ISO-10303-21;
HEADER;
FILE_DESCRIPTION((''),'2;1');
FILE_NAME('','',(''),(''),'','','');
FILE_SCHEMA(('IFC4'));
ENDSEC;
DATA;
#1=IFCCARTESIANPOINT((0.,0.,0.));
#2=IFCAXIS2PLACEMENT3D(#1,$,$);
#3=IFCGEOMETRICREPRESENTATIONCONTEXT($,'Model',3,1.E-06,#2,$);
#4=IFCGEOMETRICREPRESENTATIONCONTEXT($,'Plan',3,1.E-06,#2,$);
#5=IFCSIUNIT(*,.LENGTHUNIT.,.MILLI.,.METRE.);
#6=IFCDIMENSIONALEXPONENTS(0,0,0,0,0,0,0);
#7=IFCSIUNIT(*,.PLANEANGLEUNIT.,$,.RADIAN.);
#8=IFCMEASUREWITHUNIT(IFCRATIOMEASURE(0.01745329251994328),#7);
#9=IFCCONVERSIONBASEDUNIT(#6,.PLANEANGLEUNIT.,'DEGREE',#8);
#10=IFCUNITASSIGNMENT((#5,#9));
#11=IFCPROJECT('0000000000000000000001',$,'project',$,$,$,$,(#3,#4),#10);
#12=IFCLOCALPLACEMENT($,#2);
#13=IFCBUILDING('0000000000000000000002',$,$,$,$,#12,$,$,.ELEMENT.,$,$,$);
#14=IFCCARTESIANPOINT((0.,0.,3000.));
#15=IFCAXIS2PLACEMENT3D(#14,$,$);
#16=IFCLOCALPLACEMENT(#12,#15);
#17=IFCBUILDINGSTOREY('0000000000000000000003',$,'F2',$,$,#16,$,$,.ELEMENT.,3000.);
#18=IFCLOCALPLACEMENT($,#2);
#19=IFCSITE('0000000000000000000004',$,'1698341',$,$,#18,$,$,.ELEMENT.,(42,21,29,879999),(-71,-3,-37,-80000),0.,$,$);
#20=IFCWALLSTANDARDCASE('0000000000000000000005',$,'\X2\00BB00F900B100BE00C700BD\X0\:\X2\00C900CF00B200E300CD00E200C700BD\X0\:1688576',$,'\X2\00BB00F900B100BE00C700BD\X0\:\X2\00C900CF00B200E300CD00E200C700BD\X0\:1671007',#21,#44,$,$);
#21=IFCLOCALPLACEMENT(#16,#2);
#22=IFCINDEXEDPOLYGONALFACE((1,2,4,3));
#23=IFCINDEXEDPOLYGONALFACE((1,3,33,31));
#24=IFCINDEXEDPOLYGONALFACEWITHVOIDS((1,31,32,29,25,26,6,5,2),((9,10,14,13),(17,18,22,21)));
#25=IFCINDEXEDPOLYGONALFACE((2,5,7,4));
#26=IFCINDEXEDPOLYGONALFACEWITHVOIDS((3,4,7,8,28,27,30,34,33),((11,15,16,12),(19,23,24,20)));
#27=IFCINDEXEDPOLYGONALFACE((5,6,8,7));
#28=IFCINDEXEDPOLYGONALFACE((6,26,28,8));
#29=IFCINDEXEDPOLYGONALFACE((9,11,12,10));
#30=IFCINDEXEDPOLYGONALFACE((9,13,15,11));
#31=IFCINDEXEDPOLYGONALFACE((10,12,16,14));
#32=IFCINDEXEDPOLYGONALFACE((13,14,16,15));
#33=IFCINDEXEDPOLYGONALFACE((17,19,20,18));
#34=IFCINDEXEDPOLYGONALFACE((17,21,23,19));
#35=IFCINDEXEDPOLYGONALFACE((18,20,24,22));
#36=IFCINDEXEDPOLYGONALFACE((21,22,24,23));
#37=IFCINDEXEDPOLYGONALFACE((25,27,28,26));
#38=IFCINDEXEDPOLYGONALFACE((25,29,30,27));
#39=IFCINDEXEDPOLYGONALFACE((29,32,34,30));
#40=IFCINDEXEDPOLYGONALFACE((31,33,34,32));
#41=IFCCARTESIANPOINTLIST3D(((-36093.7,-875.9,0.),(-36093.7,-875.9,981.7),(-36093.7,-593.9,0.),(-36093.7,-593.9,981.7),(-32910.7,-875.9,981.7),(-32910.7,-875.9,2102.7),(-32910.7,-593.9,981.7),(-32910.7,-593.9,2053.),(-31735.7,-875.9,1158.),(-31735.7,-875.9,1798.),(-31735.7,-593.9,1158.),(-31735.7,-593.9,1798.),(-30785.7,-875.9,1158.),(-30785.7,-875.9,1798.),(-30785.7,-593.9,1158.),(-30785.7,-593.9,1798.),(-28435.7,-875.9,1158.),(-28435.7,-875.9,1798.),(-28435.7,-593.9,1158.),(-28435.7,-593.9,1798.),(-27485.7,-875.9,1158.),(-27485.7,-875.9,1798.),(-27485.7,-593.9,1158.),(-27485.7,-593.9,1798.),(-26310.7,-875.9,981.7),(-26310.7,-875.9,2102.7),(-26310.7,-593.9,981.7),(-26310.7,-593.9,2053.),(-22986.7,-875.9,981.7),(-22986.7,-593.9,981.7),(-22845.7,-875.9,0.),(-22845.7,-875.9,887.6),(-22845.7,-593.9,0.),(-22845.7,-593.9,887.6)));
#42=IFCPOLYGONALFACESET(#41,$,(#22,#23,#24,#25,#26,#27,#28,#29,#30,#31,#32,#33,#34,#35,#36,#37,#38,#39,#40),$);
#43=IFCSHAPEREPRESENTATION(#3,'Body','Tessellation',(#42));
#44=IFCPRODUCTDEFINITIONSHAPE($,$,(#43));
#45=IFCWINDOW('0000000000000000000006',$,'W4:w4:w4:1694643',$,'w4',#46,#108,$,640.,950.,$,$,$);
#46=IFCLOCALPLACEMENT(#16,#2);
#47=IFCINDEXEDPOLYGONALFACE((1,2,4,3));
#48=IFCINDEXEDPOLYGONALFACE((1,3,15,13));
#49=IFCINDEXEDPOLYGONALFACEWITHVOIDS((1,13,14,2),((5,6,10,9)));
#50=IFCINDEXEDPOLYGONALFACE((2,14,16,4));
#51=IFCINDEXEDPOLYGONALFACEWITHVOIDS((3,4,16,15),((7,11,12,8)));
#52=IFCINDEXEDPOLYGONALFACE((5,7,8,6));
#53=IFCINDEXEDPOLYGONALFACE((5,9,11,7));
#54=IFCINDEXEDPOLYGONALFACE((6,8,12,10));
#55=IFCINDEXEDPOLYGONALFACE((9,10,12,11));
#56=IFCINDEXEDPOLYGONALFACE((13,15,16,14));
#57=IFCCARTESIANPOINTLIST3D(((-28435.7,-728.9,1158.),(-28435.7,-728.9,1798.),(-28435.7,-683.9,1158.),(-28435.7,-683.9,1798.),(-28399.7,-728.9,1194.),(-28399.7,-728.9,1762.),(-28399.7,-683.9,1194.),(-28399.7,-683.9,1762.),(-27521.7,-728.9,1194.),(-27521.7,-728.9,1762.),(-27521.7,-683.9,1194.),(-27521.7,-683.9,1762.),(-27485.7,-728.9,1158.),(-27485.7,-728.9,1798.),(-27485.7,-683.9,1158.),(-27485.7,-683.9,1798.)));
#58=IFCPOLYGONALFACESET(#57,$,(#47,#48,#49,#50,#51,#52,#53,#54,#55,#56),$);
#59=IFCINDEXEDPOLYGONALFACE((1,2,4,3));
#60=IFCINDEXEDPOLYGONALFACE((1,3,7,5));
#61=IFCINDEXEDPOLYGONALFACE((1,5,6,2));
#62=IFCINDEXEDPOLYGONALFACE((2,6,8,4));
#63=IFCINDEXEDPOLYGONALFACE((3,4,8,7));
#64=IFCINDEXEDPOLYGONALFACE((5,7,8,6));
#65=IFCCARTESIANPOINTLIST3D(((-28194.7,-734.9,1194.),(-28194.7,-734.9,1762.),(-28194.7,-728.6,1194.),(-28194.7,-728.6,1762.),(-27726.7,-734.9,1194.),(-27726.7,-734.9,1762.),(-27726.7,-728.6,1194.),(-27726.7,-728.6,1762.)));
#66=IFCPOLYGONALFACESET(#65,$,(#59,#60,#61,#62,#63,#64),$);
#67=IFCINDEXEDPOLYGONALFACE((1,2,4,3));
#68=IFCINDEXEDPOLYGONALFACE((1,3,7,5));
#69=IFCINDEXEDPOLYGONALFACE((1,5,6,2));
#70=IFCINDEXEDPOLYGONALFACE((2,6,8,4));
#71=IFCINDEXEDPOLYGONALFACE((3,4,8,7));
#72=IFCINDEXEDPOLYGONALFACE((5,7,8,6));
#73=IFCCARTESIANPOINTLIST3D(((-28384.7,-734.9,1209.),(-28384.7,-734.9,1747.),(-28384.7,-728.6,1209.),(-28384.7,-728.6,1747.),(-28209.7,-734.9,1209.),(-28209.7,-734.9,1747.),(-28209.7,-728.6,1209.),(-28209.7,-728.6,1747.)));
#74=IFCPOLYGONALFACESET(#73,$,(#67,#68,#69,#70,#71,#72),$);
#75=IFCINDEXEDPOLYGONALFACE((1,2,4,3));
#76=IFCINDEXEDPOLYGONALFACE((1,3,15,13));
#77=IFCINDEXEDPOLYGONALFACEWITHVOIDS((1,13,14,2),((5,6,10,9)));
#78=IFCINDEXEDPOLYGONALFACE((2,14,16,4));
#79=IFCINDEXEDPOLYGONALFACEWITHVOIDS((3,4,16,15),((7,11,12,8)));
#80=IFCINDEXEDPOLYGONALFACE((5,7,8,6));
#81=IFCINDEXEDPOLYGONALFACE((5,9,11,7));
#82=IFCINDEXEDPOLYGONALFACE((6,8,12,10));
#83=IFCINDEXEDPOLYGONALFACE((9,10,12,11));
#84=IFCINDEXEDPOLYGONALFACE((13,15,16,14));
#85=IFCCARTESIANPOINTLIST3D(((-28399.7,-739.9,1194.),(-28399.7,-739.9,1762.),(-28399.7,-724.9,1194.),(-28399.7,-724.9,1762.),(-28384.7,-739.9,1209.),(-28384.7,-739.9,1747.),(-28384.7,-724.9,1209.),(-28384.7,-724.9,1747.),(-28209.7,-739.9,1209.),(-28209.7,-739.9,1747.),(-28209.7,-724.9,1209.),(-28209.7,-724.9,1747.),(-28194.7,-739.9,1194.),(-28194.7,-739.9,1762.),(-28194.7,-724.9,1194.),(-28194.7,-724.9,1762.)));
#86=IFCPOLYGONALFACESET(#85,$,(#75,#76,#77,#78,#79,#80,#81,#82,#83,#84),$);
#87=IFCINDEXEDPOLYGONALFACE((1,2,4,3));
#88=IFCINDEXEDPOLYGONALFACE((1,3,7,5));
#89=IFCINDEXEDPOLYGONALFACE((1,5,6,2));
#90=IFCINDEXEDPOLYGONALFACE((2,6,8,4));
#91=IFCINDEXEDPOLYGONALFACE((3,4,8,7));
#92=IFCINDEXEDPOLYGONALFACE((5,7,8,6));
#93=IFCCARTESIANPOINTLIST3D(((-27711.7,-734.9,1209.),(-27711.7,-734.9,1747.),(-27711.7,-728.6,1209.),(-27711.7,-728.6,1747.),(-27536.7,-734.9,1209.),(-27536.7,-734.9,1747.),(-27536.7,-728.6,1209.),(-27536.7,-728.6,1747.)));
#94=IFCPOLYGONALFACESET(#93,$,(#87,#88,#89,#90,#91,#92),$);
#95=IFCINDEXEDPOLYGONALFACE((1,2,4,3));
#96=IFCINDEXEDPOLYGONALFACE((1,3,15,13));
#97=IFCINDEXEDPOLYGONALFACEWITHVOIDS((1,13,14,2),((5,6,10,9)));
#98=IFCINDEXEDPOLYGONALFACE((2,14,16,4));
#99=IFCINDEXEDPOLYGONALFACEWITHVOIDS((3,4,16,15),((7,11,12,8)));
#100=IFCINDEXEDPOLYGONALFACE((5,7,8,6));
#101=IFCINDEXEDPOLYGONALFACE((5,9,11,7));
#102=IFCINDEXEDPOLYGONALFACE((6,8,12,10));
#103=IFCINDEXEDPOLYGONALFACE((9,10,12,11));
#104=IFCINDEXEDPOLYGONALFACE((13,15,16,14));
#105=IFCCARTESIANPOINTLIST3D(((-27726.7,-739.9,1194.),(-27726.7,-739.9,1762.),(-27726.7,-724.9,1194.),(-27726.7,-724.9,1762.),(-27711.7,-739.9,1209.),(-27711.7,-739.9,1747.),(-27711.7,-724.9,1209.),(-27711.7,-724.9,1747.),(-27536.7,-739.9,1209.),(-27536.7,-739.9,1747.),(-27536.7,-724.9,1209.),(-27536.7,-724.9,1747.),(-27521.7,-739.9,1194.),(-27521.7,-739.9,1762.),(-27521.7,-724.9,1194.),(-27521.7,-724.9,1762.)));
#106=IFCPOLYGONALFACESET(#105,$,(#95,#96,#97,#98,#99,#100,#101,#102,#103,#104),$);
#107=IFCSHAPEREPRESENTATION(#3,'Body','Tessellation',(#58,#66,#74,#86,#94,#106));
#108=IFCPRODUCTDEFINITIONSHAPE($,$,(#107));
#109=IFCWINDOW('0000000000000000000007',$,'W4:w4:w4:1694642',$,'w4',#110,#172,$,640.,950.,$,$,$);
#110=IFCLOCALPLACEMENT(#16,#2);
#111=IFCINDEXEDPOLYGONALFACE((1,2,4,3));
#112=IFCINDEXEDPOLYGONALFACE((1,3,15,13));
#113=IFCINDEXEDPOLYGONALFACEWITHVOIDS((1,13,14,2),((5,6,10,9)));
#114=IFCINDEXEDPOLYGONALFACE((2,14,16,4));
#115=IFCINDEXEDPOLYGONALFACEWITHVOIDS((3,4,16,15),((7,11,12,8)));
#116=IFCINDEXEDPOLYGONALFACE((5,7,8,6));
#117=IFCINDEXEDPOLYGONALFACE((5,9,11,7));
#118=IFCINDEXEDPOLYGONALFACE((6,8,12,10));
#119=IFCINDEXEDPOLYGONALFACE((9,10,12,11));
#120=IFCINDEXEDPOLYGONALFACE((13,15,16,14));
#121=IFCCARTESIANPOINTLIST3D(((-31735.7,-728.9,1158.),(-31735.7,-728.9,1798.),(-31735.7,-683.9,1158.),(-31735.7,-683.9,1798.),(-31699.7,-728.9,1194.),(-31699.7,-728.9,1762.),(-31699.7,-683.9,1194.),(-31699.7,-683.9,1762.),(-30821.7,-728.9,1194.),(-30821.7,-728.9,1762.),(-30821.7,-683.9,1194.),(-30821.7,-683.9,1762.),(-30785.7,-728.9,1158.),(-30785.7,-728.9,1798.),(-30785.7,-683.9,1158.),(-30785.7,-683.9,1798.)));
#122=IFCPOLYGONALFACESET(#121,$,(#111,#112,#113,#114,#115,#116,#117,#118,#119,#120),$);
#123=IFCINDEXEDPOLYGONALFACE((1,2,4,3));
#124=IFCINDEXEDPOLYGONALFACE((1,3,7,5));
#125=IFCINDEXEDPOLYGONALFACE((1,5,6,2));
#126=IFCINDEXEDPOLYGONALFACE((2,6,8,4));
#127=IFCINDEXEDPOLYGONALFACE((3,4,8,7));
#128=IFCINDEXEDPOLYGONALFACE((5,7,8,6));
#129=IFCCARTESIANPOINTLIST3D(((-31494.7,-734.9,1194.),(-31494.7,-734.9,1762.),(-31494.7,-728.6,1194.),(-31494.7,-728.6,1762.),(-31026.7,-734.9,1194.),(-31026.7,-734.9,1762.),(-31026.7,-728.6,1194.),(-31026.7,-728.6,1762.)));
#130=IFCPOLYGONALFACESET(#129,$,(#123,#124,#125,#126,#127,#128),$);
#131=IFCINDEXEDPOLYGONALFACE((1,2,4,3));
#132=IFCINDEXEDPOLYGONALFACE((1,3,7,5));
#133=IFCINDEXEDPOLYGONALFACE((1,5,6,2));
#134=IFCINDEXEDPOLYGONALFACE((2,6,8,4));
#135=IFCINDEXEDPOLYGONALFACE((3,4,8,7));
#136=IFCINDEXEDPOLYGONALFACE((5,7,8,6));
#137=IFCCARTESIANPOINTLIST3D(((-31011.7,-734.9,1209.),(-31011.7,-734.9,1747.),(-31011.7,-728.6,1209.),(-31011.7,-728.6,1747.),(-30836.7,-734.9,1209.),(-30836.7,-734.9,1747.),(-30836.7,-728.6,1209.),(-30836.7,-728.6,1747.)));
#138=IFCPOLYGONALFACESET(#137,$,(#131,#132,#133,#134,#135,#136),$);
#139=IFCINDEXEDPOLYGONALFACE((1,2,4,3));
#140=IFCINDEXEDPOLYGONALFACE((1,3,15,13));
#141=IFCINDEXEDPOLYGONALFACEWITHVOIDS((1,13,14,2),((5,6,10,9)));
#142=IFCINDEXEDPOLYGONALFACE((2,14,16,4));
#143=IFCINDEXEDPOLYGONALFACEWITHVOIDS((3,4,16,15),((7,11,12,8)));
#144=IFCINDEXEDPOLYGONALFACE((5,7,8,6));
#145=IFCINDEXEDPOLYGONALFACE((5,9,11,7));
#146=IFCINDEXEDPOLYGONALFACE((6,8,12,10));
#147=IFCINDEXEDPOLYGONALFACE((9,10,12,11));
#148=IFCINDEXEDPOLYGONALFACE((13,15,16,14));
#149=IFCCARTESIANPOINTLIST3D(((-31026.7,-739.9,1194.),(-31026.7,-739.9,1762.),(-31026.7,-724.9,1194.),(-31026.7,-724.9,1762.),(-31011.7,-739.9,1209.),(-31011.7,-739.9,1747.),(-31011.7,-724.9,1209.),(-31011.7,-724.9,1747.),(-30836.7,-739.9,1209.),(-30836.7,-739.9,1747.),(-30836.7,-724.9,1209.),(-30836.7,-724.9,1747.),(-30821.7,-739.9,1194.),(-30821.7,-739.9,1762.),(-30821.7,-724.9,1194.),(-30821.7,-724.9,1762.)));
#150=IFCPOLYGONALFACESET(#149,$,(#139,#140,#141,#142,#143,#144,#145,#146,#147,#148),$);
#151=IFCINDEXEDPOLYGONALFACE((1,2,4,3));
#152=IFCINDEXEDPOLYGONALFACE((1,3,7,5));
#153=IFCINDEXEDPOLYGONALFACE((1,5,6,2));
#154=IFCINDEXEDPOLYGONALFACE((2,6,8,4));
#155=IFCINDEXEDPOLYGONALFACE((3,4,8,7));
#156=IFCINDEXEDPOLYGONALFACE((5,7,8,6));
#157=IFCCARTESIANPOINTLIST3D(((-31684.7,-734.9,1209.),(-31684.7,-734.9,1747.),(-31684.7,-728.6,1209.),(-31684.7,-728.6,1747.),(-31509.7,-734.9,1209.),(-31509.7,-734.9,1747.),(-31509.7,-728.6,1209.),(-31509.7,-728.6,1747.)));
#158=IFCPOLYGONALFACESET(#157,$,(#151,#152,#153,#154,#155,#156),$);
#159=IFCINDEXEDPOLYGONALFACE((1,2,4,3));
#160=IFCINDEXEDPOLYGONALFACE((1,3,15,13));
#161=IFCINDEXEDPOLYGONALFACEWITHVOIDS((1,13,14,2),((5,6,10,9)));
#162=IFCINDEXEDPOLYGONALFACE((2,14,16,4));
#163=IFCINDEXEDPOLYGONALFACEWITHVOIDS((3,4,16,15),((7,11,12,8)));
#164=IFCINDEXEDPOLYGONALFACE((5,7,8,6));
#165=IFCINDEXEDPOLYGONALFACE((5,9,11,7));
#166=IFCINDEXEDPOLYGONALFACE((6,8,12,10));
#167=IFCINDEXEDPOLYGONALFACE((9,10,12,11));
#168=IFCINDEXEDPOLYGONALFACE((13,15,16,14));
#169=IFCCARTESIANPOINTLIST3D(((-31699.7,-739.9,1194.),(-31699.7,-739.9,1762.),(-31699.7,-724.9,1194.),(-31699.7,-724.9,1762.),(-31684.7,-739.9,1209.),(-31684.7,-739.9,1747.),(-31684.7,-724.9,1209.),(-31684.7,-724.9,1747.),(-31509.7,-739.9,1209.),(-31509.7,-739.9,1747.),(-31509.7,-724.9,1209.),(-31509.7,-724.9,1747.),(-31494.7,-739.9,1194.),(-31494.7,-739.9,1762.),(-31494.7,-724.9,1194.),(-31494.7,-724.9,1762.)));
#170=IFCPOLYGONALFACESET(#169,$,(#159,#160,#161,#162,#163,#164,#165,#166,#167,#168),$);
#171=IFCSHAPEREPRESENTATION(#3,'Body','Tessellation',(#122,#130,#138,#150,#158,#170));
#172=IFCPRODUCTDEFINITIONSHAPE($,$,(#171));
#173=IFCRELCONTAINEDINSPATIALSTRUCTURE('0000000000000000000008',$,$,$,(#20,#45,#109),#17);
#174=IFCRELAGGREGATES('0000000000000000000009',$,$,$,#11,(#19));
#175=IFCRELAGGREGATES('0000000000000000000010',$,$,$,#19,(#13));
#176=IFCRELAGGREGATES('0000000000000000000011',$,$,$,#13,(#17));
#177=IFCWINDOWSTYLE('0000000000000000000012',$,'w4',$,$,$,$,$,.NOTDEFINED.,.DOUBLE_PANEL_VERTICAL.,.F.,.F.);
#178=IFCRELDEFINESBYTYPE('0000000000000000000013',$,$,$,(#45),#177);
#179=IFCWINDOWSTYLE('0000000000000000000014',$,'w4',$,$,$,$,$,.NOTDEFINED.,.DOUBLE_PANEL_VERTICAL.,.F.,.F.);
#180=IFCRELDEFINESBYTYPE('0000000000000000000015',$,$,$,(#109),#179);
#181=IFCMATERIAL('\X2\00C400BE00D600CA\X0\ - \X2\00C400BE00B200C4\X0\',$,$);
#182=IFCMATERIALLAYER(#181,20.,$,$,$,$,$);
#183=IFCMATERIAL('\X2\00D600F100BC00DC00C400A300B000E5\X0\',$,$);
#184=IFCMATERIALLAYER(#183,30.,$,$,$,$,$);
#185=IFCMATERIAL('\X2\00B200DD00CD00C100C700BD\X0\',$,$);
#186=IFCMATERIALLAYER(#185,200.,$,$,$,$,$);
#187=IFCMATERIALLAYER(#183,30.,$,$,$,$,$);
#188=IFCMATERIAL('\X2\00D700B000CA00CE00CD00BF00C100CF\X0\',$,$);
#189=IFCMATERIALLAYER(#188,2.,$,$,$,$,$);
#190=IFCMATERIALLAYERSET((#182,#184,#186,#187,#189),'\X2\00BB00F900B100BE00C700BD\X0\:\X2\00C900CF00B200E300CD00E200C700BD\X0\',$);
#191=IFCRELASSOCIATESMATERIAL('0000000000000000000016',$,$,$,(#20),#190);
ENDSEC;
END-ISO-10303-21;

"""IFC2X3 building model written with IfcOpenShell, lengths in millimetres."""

from ifc_helpers import new_model, entity, si_unit, converted_unit, frame, frame_2d, origin, origin_2d_with_axis, place, context, project, spatial, polyline, rectangle, outline, extrude, clip, halfspace, bounded_halfspace, source, transform, mapped, material, layer, layer_set, layer_usage, type_object, type_shapes, element, fill, save


model = new_model("IFC2X3")

# Units and contexts
model_context = context("Model", 3, precision=1e-06, world=origin())
plan_context = context("Plan", 3, precision=1e-06, world=origin())
ifc_project = project(units=[si_unit("LENGTHUNIT", "METRE", prefix="MILLI"), converted_unit("PLANEANGLEUNIT", "DEGREE", entity("IfcRatioMeasure", 0.01745329251994328), si_unit("PLANEANGLEUNIT", "RADIAN"), dimensions=[0, 0, 0, 0, 0, 0, 0])], contexts=[model_context, plan_context])

# Site, building, storey
site_placement = place(None, origin())
site = spatial("IfcSite", under=ifc_project, at=site_placement, Name="1698341", CompositionType="ELEMENT", RefLatitude=(42, 21, 29, 879999), RefLongitude=(-71, -3, -37, -80000), RefElevation=0.0)
building_placement = place(None, origin())
building = spatial("IfcBuilding", under=site, at=building_placement, CompositionType="ELEMENT")
storey_placement = place(building_placement, frame((0.0, 0.0, 3000.0)))
storey = spatial("IfcBuildingStorey", under=building, at=storey_placement, Name="F2", CompositionType="ELEMENT", Elevation=3000.0)

# Shared definitions
ifc_material_1 = material(Name="Öñ¼ÜÄ£°å")

# Shared definitions
ifc_material_2 = material(Name="Ä¾ÖÊ - Ä¾²Ä")
ifc_layer_1 = layer(ifc_material_2, 20.0)
ifc_layer_2 = layer(ifc_material_1, 30.0)
ifc_material_3 = material(Name="²ÝÍÁÇ½")
ifc_layer_3 = layer(ifc_material_3, 200.0)
ifc_layer_4 = layer(ifc_material_1, 30.0)
ifc_material_4 = material(Name="×°ÊÎÍ¿ÁÏ")
ifc_layer_5 = layer(ifc_material_4, 2.0)
ifc_layer_set_1 = layer_set([ifc_layer_1, ifc_layer_2, ifc_layer_3, ifc_layer_4, ifc_layer_5], Name="»ù±¾Ç½:ÉÏ²ãÍâÇ½")

# Wall, openings, windows
ifc_layer_usage_1 = layer_usage(ifc_layer_set_1, "AXIS2", "NEGATIVE", 141.0)
wall_1_placement = place(storey_placement, frame((-36093.7, -734.9, 0.0)))
wall_1 = element("IfcWallStandardCase", 1, at=wall_1_placement, inside=storey, material=ifc_layer_usage_1, Name="»ù±¾Ç½:ÉÏ²ãÍâÇ½:1688576", ObjectType="»ù±¾Ç½:ÉÏ²ãÍâÇ½:1671007", context=model_context, shape_type="Clipping", body=[
    clip(clip(clip(extrude(rectangle(XDim=13248.0, YDim=282.0, at=frame_2d((6624.0, 0.0), x_axis=(-1.0, 0.0))), origin(), (0.0, 0.0, 1.0), 3200.0), bounded_halfspace(frame((3098.0, -141.0, 2102.7), z_axis=(0.0, -0.173648, -0.984808), x_axis=(-1.0, 0.0, 0.0)), True, frame((3098.0, -141.0, 2102.7)), polyline([(0.0, 0.0), (170.0, 0.0), (3280.0, 0.0), (3490.0, 0.0), (6600.0, 0.0), (6770.0, 0.0), (6770.0, 282.0), (0.0, 282.0), (0.0, 0.0)]))), halfspace(frame((13107.0, 0.0, 981.7), z_axis=(0.5551, 0.0, 0.831784), x_axis=(0.0, 1.0, 0.0)), False)), halfspace(frame((3183.0, 0.0, 3200.0), z_axis=(-0.5551, 0.0, 0.831784), x_axis=(0.0, 1.0, 0.0)), False)),
])
opening_1_placement = place(wall_1_placement, origin())
opening_1 = element("IfcOpeningElement", 2, at=opening_1_placement, cuts=wall_1, ObjectType="Opening", context=model_context, shape_type="SweptSolid", body=[
    extrude(rectangle(XDim=640.0, YDim=950.0, at=origin_2d_with_axis()), frame((4833.0, -141.0, 1478.0), z_axis=(0.0, 1.0, 0.0), x_axis=(0.0, 0.0, 1.0)), (0.0, 0.0, 1.0), 282.0),
])
opening_2_placement = place(wall_1_placement, origin())
opening_2 = element("IfcOpeningElement", 3, at=opening_2_placement, cuts=wall_1, ObjectType="Opening", context=model_context, shape_type="SweptSolid", body=[
    extrude(rectangle(XDim=640.0, YDim=950.0, at=frame_2d((0.0, 0.0), x_axis=(0.0, 1.0))), frame((8133.0, -141.0, 1478.0), z_axis=(0.0, 1.0, 0.0), x_axis=(-1.0, 0.0, 0.0)), (0.0, 0.0, 1.0), 282.0),
])
opening_3_placement = place(wall_1_placement, frame((10891.0, 141.0, 1721.1)))
element("IfcOpeningElement", 4, at=opening_3_placement, cuts=wall_1, ObjectType="Opening", context=model_context, shape_type="SweptSolid", body=[
    extrude(outline(polyline([(-2253.7, -615.1), (1742.5, -615.1), (511.2, 1230.1), (-2253.7, -615.1)])), frame((0.0, 0.0, 0.0), z_axis=(0.0, -1.0, 0.0), x_axis=(-0.831784, 0.0, 0.5551)), (0.0, 0.0, 1.0), 282.0),
])
opening_4_placement = place(wall_1_placement, frame((2075.0, 141.0, 1721.1)))
element("IfcOpeningElement", 5, at=opening_4_placement, cuts=wall_1, ObjectType="Opening", context=model_context, shape_type="SweptSolid", body=[
    extrude(outline(polyline([(-1742.5, -615.1), (2253.7, -615.1), (-511.2, 1230.1), (-1742.5, -615.1)])), frame((0.0, 0.0, 0.0), z_axis=(0.0, -1.0, 0.0), x_axis=(-0.831784, 0.0, -0.5551)), (0.0, 0.0, 1.0), 282.0),
])
window_style_1 = type_object("IfcWindowStyle", Name="w4", ConstructionType="NOTDEFINED", OperationType="DOUBLE_PANEL_VERTICAL", ParameterTakesPrecedence=False, Sizeable=False)
shared_shape_1 = source(origin(), model_context, "Body", "SweptSolid", [
    extrude(outline(polyline([(-320.0, -475.0), (320.0, -475.0), (320.0, 475.0), (-320.0, 475.0), (-320.0, -475.0)]), holes=[polyline([(284.0, -439.0), (-284.0, -439.0), (-284.0, 439.0), (284.0, 439.0), (284.0, -439.0)])]), frame((475.0, -135.0, 320.0), z_axis=(0.0, 1.0, 0.0), x_axis=(0.0, 0.0, 1.0)), (0.0, 0.0, 1.0), 45.0),
    extrude(rectangle(XDim=6.3, YDim=468.0, at=origin_2d_with_axis()), frame((475.0, -137.9, 36.0), z_axis=(0.0, 0.0, 1.0), x_axis=(0.0, 1.0, 0.0)), (0.0, 0.0, 1.0), 568.0),
    extrude(rectangle(XDim=6.3, YDim=175.0, at=origin_2d_with_axis()), frame((138.5, -137.9, 51.0), z_axis=(0.0, 0.0, 1.0), x_axis=(0.0, 1.0, 0.0)), (0.0, 0.0, 1.0), 538.0),
    extrude(outline(polyline([(-102.5, -284.0), (102.5, -284.0), (102.5, 284.0), (-102.5, 284.0), (-102.5, -284.0)]), holes=[polyline([(87.5, -269.0), (-87.5, -269.0), (-87.5, 269.0), (87.5, 269.0), (87.5, -269.0)])]), frame((138.5, -146.0, 320.0), z_axis=(0.0, 1.0, 0.0), x_axis=(-1.0, 0.0, 0.0)), (0.0, 0.0, 1.0), 15.0),
    extrude(rectangle(XDim=6.3, YDim=175.0, at=origin_2d_with_axis()), frame((811.5, -137.9, 51.0), z_axis=(0.0, 0.0, 1.0), x_axis=(0.0, 1.0, 0.0)), (0.0, 0.0, 1.0), 538.0),
    extrude(outline(polyline([(-102.5, -284.0), (102.5, -284.0), (102.5, 284.0), (-102.5, 284.0), (-102.5, -284.0)]), holes=[polyline([(87.5, -269.0), (-87.5, -269.0), (-87.5, 269.0), (87.5, 269.0), (87.5, -269.0)])]), frame((811.5, -146.0, 320.0), z_axis=(0.0, 1.0, 0.0), x_axis=(-1.0, 0.0, 0.0)), (0.0, 0.0, 1.0), 15.0),
])
type_shapes(window_style_1, [shared_shape_1])
window_1_placement = place(opening_2_placement, frame((7658.0, 141.0, 1158.0)))
window_1 = element("IfcWindow", 6, at=window_1_placement, inside=storey, type_object=window_style_1, Name="W4:w4:w4:1694643", ObjectType="w4", OverallHeight=640.0, OverallWidth=950.0, context=model_context, shape_type="MappedRepresentation", body=[
    mapped(shared_shape_1, transform((0.0, 0.0, 0.0), scale=1.0)),
])
fill(opening_2, window_1)
window_style_2 = type_object("IfcWindowStyle", Name="w4", ConstructionType="NOTDEFINED", OperationType="DOUBLE_PANEL_VERTICAL", ParameterTakesPrecedence=False, Sizeable=False)
shared_shape_2 = source(origin(), model_context, "Body", "SweptSolid", [
    extrude(outline(polyline([(-475.0, -320.0), (475.0, -320.0), (475.0, 320.0), (-475.0, 320.0), (-475.0, -320.0)]), holes=[polyline([(-439.0, 284.0), (439.0, 284.0), (439.0, -284.0), (-439.0, -284.0), (-439.0, 284.0)])]), frame((-177.3, 192.0, 320.0), z_axis=(0.0, -1.0, 0.0), x_axis=(-1.0, 0.0, 0.0)), (0.0, 0.0, 1.0), 45.0),
    extrude(rectangle(XDim=468.0, YDim=6.3, at=origin_2d_with_axis()), frame((-177.3, 144.1, 36.0)), (0.0, 0.0, 1.0), 568.0),
    extrude(rectangle(XDim=175.0, YDim=6.3, at=origin_2d_with_axis()), frame((159.2, 144.1, 51.0)), (0.0, 0.0, 1.0), 538.0),
    extrude(outline(polyline([(-284.0, -102.5), (284.0, -102.5), (284.0, 102.5), (-284.0, 102.5), (-284.0, -102.5)]), holes=[polyline([(-269.0, 87.5), (269.0, 87.5), (269.0, -87.5), (-269.0, -87.5), (-269.0, 87.5)])]), frame((159.2, 151.0, 320.0), z_axis=(0.0, -1.0, 0.0), x_axis=(0.0, 0.0, 1.0)), (0.0, 0.0, 1.0), 15.0),
    extrude(rectangle(XDim=175.0, YDim=6.3, at=origin_2d_with_axis()), frame((-513.8, 144.1, 51.0)), (0.0, 0.0, 1.0), 538.0),
    extrude(outline(polyline([(-284.0, -102.5), (284.0, -102.5), (284.0, 102.5), (-284.0, 102.5), (-284.0, -102.5)]), holes=[polyline([(-269.0, 87.5), (269.0, 87.5), (269.0, -87.5), (-269.0, -87.5), (-269.0, 87.5)])]), frame((-513.8, 151.0, 320.0), z_axis=(0.0, -1.0, 0.0), x_axis=(0.0, 0.0, 1.0)), (0.0, 0.0, 1.0), 15.0),
])
type_shapes(window_style_2, [shared_shape_2])
window_2_placement = place(opening_1_placement, frame((5010.3, -141.0, 1158.0)))
window_2 = element("IfcWindow", 7, at=window_2_placement, inside=storey, type_object=window_style_2, Name="W4:w4:w4:1694642", ObjectType="w4", OverallHeight=640.0, OverallWidth=950.0, context=model_context, shape_type="MappedRepresentation", body=[
    mapped(shared_shape_2, transform((0.0, 0.0, 0.0), scale=1.0)),
])
fill(opening_1, window_2)

save(model, "model.ifc")
